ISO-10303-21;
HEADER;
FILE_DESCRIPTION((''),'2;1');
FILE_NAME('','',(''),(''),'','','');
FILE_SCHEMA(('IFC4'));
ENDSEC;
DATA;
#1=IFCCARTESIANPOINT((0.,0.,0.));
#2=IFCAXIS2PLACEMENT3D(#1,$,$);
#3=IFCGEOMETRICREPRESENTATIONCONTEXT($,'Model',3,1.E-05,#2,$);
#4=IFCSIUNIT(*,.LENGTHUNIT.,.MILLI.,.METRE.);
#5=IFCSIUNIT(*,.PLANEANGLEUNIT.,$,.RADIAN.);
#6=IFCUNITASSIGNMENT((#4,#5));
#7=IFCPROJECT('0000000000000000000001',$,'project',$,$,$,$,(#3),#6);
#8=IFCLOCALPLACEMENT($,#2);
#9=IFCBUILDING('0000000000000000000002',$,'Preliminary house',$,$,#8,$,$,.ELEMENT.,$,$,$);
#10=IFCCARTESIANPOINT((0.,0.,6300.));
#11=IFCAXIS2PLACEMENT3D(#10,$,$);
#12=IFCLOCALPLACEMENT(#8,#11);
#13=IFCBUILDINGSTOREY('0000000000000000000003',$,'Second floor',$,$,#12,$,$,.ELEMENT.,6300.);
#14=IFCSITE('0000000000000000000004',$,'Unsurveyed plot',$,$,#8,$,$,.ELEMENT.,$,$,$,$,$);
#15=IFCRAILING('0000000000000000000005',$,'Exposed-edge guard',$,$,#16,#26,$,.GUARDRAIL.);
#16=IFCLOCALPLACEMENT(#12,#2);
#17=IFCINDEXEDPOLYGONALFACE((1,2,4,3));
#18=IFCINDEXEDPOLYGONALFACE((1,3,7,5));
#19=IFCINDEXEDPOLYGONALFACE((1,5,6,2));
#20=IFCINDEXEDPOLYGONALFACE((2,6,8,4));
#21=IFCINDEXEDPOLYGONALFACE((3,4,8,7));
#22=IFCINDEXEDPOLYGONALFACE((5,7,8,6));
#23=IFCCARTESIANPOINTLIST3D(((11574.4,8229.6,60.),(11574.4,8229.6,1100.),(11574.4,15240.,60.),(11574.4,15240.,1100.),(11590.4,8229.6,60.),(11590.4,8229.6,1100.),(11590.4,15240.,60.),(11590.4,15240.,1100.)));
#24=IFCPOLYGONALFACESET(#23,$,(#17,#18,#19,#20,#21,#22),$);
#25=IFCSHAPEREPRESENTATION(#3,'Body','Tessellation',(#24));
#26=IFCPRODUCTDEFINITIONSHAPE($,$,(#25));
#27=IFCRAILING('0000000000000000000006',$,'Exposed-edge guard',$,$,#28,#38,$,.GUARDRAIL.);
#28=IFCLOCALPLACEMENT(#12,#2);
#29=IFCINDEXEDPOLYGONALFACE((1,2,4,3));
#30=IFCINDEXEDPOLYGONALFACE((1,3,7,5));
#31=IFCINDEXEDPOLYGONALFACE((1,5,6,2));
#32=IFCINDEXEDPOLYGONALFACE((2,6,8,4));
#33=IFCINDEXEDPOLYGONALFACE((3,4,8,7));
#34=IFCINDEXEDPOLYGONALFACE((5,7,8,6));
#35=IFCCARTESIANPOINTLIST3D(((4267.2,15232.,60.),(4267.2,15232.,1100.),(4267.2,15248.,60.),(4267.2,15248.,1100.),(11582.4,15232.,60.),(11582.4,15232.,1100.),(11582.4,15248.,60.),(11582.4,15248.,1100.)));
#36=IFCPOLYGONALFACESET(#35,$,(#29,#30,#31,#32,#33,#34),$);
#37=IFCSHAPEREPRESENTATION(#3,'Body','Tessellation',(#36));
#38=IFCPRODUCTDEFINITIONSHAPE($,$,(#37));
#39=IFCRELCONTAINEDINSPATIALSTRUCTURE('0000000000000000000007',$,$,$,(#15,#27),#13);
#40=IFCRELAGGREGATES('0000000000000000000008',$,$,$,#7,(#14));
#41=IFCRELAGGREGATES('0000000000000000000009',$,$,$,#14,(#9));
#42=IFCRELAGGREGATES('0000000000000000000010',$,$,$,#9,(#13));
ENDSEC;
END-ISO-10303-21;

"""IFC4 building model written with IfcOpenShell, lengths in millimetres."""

from ifc_helpers import new_model, si_unit, frame, origin, place, context, project, spatial, polyline, outline, extrude, element, save


model = new_model("IFC4")

# Units and contexts
model_context = context("Model", 3, precision=1e-05, world=origin())
ifc_project = project(units=[si_unit("LENGTHUNIT", "METRE", prefix="MILLI"), si_unit("PLANEANGLEUNIT", "RADIAN")], contexts=[model_context])

# Site, building, storey
placement_1 = place(None, origin())
site = spatial("IfcSite", under=ifc_project, at=placement_1, Name="Unsurveyed plot", CompositionType="ELEMENT")
building = spatial("IfcBuilding", under=site, at=placement_1, Name="Preliminary house", CompositionType="ELEMENT")
placement_2 = place(placement_1, frame((0.0, 0.0, 6300.0)))
storey = spatial("IfcBuildingStorey", under=building, at=placement_2, Name="Second floor", CompositionType="ELEMENT", Elevation=6300.0)

# Railings
element("IfcRailing", 1, at=placement_2, inside=storey, Name="Exposed-edge guard", PredefinedType="GUARDRAIL", context=model_context, shape_type="SweptSolid", body=[
    extrude(outline(polyline([(11590.4, 8229.6), (11574.4, 8229.6), (11574.4, 15240.0), (11590.4, 15240.0), (11590.4, 8229.6)])), frame((0.0, 0.0, 60.0)), (0.0, 0.0, 1.0), 1040.0),
])
element("IfcRailing", 2, at=placement_2, inside=storey, Name="Exposed-edge guard", PredefinedType="GUARDRAIL", context=model_context, shape_type="SweptSolid", body=[
    extrude(outline(polyline([(4267.2, 15232.0), (4267.2, 15248.0), (11582.4, 15248.0), (11582.4, 15232.0), (4267.2, 15232.0)])), frame((0.0, 0.0, 60.0)), (0.0, 0.0, 1.0), 1040.0),
])

save(model, "model.ifc")
